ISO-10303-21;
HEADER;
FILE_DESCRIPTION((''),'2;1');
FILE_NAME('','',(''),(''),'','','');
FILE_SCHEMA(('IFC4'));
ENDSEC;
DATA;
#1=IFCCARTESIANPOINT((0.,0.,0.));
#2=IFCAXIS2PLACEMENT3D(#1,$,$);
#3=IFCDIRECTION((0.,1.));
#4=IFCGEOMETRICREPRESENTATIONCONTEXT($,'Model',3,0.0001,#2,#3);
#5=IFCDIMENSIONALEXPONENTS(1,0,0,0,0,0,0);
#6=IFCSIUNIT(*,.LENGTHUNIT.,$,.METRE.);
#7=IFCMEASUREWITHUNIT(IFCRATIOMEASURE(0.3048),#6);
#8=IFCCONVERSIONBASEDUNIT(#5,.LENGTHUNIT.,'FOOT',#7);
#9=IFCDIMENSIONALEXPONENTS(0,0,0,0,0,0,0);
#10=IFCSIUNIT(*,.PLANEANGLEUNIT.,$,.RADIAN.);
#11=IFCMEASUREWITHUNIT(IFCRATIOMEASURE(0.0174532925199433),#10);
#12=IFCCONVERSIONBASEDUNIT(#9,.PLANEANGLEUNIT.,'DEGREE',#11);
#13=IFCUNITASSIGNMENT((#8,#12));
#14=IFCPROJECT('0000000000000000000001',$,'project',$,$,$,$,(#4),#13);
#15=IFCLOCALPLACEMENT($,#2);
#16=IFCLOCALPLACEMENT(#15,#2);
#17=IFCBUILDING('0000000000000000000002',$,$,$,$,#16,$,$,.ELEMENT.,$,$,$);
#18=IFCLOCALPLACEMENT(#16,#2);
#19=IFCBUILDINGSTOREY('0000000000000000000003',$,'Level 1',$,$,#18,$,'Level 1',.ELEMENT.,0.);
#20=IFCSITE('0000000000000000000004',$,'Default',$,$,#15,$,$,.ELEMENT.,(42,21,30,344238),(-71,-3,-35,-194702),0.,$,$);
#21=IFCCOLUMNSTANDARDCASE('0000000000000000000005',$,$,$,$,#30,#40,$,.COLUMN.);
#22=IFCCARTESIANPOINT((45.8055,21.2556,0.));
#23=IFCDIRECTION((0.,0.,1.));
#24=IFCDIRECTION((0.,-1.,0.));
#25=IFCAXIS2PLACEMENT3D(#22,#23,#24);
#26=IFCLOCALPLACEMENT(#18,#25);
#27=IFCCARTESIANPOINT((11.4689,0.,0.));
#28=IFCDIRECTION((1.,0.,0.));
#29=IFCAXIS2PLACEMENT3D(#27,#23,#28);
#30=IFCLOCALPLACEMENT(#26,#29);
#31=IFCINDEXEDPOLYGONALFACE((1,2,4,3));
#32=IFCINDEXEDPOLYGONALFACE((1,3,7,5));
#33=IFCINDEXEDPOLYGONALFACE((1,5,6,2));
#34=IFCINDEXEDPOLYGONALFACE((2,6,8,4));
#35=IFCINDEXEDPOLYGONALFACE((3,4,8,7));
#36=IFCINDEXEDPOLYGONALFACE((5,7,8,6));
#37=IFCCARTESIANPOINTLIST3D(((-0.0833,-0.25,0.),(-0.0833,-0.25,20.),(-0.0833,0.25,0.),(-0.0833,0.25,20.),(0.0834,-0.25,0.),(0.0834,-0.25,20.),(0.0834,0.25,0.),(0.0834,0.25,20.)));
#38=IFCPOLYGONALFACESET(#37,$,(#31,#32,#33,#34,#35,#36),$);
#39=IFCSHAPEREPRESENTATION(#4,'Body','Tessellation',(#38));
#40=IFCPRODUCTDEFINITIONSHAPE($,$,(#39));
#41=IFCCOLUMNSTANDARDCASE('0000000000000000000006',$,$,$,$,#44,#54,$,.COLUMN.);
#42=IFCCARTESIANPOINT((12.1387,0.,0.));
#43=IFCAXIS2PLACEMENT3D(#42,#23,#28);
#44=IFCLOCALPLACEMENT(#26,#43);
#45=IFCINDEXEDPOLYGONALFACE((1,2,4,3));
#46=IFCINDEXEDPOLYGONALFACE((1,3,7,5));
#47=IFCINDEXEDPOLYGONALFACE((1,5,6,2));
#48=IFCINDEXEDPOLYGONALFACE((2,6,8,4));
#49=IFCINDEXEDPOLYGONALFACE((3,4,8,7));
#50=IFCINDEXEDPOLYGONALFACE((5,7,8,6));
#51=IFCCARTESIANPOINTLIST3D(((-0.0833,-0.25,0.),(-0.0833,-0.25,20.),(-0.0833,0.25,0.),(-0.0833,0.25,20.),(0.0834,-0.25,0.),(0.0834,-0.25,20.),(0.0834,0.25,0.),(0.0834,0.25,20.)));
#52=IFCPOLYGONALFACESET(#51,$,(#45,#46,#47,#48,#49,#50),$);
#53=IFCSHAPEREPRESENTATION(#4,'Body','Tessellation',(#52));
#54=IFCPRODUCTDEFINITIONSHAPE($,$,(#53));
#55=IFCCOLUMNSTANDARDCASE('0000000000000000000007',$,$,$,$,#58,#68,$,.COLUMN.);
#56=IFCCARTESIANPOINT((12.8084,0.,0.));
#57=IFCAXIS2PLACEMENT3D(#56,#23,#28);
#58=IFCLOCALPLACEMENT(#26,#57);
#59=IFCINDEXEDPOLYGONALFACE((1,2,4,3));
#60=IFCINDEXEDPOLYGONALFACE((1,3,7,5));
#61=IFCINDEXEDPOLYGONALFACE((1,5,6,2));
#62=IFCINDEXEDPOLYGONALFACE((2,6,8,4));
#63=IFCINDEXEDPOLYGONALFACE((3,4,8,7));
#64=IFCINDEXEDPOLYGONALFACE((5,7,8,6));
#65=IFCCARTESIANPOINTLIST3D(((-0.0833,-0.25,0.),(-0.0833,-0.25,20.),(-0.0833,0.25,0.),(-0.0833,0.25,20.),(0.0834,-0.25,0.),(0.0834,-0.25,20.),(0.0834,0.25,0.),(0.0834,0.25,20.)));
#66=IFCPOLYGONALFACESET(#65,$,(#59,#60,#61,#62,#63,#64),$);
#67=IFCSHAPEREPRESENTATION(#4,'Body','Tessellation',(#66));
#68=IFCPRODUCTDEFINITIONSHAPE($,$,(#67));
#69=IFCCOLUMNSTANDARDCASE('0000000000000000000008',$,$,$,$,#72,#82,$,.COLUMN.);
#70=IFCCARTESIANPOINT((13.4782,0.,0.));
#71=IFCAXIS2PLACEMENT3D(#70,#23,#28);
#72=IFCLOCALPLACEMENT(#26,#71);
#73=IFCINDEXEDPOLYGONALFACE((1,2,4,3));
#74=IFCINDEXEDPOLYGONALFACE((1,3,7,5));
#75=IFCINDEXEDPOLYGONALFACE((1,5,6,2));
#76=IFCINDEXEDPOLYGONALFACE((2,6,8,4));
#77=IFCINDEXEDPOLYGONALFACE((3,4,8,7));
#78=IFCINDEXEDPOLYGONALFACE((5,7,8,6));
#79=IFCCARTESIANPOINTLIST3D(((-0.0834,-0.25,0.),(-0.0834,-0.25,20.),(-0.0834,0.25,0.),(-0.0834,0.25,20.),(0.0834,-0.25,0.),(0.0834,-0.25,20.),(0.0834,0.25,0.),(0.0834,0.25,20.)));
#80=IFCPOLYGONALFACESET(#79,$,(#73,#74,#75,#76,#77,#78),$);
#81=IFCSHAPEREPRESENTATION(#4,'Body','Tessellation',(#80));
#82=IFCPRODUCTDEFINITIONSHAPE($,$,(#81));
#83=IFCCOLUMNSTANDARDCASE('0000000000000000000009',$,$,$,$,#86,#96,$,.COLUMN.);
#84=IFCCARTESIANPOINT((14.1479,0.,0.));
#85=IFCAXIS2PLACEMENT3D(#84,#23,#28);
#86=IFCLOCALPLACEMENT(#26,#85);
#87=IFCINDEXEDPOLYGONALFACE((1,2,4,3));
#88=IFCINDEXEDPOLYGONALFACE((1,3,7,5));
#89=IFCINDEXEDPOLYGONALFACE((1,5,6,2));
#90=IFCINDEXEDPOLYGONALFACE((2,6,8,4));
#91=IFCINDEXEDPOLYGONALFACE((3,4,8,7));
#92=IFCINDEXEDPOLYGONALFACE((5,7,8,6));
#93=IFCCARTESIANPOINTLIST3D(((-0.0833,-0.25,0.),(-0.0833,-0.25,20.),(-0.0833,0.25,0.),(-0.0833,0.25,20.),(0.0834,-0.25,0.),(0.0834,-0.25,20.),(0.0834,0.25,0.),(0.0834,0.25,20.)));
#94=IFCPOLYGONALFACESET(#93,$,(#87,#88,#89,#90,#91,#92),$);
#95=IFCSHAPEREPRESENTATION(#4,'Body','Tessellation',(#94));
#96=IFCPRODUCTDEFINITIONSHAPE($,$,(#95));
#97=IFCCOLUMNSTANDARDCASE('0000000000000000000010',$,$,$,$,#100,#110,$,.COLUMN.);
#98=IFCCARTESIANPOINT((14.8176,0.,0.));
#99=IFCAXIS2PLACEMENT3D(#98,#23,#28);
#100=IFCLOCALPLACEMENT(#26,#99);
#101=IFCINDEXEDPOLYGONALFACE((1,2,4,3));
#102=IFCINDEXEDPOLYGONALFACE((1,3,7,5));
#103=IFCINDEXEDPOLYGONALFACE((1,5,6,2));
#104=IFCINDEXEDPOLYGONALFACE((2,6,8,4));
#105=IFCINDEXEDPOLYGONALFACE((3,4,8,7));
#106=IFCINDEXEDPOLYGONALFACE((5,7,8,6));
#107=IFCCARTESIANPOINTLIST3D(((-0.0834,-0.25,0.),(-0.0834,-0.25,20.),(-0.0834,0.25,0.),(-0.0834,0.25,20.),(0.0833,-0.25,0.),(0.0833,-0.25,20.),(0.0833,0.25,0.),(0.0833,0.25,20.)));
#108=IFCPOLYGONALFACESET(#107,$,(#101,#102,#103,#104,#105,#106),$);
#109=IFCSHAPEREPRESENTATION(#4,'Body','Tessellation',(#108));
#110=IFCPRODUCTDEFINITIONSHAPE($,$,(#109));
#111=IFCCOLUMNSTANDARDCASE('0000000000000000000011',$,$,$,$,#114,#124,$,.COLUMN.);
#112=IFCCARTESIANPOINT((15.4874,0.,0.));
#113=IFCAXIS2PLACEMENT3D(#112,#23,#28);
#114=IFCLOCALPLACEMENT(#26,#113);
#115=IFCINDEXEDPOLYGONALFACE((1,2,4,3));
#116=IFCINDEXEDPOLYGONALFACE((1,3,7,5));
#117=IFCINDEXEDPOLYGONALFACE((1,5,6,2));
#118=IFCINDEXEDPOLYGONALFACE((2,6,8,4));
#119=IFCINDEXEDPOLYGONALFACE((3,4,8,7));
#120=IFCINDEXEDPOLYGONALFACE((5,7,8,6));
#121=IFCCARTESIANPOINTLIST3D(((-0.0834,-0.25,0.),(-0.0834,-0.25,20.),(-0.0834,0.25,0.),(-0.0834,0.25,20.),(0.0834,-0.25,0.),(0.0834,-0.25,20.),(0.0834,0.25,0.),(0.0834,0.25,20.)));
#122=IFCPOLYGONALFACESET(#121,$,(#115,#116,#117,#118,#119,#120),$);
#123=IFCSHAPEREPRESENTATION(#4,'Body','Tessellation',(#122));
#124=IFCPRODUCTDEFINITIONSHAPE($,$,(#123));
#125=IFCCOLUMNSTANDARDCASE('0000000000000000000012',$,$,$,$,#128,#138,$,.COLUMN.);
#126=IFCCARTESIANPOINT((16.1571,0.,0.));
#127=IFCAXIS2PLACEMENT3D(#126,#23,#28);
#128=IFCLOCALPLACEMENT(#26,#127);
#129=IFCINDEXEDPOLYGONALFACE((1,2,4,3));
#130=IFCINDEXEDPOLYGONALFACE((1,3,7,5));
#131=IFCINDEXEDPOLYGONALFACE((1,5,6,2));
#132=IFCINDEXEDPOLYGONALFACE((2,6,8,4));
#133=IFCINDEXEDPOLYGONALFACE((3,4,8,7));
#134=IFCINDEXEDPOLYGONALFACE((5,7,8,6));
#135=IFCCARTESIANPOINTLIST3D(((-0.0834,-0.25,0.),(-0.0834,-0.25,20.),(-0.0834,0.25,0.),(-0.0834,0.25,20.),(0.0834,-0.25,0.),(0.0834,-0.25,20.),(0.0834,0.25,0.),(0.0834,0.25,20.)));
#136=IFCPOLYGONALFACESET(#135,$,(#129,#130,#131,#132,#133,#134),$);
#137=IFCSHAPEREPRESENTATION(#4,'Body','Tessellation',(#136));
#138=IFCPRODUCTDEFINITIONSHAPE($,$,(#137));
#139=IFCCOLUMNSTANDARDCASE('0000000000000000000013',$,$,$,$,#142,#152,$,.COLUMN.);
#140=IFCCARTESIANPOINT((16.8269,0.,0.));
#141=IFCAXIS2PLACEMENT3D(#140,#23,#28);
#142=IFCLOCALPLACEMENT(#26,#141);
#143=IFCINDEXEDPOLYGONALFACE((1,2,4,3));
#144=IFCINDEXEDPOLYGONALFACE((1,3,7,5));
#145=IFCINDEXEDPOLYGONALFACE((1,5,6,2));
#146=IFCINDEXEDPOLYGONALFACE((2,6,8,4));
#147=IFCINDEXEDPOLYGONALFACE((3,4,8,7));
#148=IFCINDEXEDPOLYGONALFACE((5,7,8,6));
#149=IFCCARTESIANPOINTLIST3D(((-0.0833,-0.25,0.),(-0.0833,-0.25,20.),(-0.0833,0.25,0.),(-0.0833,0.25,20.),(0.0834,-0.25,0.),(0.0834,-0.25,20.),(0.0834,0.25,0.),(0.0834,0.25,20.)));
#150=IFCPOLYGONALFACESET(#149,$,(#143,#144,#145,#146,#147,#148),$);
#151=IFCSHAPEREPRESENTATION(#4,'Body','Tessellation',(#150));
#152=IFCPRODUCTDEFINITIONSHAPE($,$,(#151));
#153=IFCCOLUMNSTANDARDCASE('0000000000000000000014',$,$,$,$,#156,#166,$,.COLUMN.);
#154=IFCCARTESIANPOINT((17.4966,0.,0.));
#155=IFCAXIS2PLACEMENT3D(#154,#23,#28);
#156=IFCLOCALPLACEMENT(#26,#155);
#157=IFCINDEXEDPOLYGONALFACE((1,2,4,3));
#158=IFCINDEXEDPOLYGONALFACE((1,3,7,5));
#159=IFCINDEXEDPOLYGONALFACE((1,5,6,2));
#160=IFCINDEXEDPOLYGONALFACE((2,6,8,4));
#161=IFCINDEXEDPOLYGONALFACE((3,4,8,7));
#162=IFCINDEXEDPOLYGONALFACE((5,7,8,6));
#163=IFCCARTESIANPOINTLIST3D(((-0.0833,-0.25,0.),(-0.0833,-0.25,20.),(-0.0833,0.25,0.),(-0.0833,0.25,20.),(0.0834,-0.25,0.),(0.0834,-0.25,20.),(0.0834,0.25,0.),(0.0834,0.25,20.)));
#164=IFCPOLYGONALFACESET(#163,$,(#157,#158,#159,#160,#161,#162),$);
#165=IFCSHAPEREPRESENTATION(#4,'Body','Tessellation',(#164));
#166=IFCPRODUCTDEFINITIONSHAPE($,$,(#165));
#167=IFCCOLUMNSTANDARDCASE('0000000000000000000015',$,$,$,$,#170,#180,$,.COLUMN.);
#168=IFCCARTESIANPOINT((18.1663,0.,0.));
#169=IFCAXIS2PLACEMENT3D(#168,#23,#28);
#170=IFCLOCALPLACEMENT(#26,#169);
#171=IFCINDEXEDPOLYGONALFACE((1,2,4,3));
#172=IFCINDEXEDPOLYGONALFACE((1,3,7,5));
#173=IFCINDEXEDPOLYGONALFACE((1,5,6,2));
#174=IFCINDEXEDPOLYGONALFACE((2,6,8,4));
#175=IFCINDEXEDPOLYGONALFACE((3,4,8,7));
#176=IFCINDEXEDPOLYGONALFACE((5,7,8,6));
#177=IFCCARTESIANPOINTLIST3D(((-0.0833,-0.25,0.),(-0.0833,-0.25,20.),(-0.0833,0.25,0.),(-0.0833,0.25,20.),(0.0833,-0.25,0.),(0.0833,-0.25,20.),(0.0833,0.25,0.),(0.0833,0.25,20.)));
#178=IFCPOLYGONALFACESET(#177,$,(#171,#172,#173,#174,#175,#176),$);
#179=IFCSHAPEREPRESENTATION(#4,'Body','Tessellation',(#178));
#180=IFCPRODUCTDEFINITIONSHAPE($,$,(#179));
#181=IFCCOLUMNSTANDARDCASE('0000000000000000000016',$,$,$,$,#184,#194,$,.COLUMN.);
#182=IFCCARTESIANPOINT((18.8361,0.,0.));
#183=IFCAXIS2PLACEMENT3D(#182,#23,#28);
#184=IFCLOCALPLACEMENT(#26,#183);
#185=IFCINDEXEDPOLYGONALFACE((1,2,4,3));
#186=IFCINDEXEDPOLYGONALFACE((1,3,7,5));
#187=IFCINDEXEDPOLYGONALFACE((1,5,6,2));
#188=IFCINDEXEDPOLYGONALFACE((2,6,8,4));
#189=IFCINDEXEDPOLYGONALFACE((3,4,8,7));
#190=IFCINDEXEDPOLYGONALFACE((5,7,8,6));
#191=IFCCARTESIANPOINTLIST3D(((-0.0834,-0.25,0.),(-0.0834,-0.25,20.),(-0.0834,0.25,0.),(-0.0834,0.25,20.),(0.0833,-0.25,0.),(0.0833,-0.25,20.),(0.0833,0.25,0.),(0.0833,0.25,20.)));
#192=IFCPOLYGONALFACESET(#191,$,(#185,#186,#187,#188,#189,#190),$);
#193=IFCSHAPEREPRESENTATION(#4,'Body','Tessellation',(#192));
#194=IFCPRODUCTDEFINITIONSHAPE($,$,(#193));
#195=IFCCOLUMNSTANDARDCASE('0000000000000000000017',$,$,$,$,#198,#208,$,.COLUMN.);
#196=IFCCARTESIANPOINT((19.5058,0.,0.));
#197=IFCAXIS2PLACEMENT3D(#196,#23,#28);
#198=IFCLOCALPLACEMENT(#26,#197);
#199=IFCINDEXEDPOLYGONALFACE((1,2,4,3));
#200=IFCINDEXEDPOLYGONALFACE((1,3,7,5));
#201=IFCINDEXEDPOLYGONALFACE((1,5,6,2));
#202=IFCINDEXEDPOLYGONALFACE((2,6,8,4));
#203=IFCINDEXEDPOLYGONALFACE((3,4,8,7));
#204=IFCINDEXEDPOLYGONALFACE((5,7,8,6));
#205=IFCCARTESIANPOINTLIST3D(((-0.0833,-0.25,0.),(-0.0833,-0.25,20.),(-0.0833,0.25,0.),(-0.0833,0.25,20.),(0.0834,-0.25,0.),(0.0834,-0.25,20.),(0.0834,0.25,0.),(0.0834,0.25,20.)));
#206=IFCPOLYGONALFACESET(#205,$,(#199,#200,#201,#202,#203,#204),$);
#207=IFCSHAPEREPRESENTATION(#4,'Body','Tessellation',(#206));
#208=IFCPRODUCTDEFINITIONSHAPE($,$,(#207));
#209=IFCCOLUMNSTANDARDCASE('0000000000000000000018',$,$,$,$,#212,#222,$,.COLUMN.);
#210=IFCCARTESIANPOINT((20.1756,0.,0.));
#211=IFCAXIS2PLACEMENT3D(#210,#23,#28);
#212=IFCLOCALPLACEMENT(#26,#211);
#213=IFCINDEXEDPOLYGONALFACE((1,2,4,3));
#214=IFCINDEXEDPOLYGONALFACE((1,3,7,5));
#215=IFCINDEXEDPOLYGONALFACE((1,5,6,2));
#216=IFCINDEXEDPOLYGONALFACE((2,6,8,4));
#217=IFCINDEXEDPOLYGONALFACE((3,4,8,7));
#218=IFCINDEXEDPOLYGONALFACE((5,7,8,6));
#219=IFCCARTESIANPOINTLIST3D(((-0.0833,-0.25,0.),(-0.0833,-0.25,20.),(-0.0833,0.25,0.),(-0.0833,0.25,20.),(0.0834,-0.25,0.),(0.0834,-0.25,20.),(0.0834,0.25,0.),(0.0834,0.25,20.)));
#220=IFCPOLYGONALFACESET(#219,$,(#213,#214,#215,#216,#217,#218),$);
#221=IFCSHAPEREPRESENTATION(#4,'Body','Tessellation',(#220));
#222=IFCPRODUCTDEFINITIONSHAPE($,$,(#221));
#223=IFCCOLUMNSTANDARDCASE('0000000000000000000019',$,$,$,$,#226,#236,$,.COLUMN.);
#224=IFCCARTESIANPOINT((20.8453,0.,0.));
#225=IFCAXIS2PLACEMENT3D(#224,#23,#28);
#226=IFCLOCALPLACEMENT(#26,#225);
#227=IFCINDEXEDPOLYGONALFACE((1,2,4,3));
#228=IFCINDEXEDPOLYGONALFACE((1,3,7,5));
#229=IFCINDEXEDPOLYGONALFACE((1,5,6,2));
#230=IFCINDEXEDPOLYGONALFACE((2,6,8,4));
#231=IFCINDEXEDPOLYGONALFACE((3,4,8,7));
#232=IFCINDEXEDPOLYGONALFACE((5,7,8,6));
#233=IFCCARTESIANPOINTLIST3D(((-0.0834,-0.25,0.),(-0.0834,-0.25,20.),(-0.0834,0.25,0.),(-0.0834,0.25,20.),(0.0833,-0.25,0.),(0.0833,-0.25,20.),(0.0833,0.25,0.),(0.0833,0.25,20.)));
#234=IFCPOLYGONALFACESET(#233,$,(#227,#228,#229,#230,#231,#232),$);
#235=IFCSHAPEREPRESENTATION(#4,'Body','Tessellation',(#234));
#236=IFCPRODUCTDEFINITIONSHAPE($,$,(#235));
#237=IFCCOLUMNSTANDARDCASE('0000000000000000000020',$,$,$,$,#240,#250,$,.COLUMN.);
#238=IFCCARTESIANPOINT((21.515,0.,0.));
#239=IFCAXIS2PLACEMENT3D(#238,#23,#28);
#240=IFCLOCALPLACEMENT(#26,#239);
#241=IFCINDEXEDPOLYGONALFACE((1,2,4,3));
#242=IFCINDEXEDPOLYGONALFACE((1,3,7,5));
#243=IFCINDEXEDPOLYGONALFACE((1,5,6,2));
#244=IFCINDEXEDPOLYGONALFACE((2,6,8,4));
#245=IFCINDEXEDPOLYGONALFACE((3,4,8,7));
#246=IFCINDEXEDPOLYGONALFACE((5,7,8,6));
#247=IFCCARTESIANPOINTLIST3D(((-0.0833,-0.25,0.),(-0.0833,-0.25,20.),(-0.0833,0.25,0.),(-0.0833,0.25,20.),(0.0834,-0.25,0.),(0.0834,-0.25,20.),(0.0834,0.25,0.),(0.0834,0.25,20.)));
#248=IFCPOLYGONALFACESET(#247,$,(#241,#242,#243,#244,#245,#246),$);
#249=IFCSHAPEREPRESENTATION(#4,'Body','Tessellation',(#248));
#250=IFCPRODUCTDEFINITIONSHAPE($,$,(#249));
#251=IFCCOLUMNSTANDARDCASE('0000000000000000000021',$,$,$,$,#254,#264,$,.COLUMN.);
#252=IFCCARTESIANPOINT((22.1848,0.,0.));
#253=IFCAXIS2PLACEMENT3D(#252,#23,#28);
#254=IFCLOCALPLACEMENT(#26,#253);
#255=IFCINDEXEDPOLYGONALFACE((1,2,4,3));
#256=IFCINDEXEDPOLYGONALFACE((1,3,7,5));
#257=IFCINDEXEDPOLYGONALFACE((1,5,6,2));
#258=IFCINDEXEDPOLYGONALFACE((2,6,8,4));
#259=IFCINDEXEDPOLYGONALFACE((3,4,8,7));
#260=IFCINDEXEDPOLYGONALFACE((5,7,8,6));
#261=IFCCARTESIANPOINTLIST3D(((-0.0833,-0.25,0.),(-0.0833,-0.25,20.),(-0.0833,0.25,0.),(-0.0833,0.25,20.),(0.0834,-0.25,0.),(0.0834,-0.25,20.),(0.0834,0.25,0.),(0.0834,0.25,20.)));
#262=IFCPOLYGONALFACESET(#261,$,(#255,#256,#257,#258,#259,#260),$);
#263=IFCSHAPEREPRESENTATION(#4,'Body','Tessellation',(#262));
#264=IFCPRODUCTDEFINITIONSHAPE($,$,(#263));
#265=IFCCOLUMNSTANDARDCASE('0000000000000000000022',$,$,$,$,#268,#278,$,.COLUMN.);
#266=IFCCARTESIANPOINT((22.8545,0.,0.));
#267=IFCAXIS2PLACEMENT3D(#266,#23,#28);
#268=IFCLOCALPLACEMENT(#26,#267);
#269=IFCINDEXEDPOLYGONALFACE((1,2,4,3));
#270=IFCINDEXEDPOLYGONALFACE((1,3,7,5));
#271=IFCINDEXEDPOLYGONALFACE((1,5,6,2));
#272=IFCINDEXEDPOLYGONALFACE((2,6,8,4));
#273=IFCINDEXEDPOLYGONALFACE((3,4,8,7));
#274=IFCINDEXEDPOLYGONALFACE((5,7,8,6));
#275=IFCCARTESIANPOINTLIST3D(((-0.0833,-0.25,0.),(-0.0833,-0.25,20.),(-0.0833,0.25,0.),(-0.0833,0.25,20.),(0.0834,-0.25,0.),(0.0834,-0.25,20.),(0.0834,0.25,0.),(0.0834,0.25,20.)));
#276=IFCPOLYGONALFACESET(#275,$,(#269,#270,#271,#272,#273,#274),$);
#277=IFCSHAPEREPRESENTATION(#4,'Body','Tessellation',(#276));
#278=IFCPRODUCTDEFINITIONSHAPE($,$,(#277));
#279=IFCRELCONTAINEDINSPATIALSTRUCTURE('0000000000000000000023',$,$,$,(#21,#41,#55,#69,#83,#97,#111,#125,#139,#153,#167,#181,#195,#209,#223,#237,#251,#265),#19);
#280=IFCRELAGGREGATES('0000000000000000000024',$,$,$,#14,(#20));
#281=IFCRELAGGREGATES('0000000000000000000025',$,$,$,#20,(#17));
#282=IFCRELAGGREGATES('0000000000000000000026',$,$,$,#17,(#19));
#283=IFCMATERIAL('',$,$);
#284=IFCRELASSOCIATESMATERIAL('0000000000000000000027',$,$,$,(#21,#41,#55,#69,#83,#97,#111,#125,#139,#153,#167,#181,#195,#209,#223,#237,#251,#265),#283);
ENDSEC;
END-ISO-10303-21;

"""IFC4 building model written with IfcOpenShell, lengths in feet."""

from ifc_helpers import new_model, entity, si_unit, converted_unit, direction, frame, origin, place, context, project, spatial, rectangle, extrude, material, element, save


model = new_model("IFC4")

# Units and contexts
model_context = context("Model", 3, precision=0.0001, world=origin(), true_north=direction((0.0, 1.0)))
ifc_project = project(units=[converted_unit("LENGTHUNIT", "FOOT", entity("IfcRatioMeasure", 0.3048), si_unit("LENGTHUNIT", "METRE"), dimensions=[1, 0, 0, 0, 0, 0, 0]), converted_unit("PLANEANGLEUNIT", "DEGREE", entity("IfcRatioMeasure", 0.0174532925199433), si_unit("PLANEANGLEUNIT", "RADIAN"), dimensions=[0, 0, 0, 0, 0, 0, 0])], contexts=[model_context])

# Site, building, storey
site_placement = place(None, origin())
site = spatial("IfcSite", under=ifc_project, at=site_placement, Name="Default", CompositionType="ELEMENT", RefLatitude=(42, 21, 30, 344238), RefLongitude=(-71, -3, -35, -194702), RefElevation=0.0)
building_placement = place(site_placement, origin())
building = spatial("IfcBuilding", under=site, at=building_placement, CompositionType="ELEMENT")
storey_placement = place(building_placement, origin())
storey = spatial("IfcBuildingStorey", under=building, at=storey_placement, Name="Level 1", LongName="Level 1", CompositionType="ELEMENT", Elevation=0.0)

# Columns
ifc_material_1 = material(Name="")
placement = place(storey_placement, frame((45.8055, 21.2556, 0.0), z_axis=(0.0, 0.0, 1.0), x_axis=(0.0, -1.0, 0.0)))
for number, where, z_axis, x_axis in (
    (1, (11.4689, 0.0, 0.0), (0.0, 0.0, 1.0), (1.0, 0.0, 0.0)),
    (2, (12.1387, 0.0, 0.0), (0.0, 0.0, 1.0), (1.0, 0.0, 0.0)),
    (3, (12.8084, 0.0, 0.0), (0.0, 0.0, 1.0), (1.0, 0.0, 0.0)),
    (4, (13.4782, 0.0, 0.0), (0.0, 0.0, 1.0), (1.0, 0.0, 0.0)),
    (5, (14.1479, 0.0, 0.0), (0.0, 0.0, 1.0), (1.0, 0.0, 0.0)),
    (6, (14.8176, 0.0, 0.0), (0.0, 0.0, 1.0), (1.0, 0.0, 0.0)),
    (7, (15.4874, 0.0, 0.0), (0.0, 0.0, 1.0), (1.0, 0.0, 0.0)),
    (8, (16.1571, 0.0, 0.0), (0.0, 0.0, 1.0), (1.0, 0.0, 0.0)),
    (9, (16.8269, 0.0, 0.0), (0.0, 0.0, 1.0), (1.0, 0.0, 0.0)),
    (10, (17.4966, 0.0, 0.0), (0.0, 0.0, 1.0), (1.0, 0.0, 0.0)),
    (11, (18.1663, 0.0, 0.0), (0.0, 0.0, 1.0), (1.0, 0.0, 0.0)),
    (12, (18.8361, 0.0, 0.0), (0.0, 0.0, 1.0), (1.0, 0.0, 0.0)),
    (13, (19.5058, 0.0, 0.0), (0.0, 0.0, 1.0), (1.0, 0.0, 0.0)),
    (14, (20.1756, 0.0, 0.0), (0.0, 0.0, 1.0), (1.0, 0.0, 0.0)),
    (15, (20.8453, 0.0, 0.0), (0.0, 0.0, 1.0), (1.0, 0.0, 0.0)),
    (16, (21.515, 0.0, 0.0), (0.0, 0.0, 1.0), (1.0, 0.0, 0.0)),
    (17, (22.1848, 0.0, 0.0), (0.0, 0.0, 1.0), (1.0, 0.0, 0.0)),
    (18, (22.8545, 0.0, 0.0), (0.0, 0.0, 1.0), (1.0, 0.0, 0.0)),
):
    element("IfcColumnStandardCase", number, at=place(placement, frame(where, z_axis=z_axis, x_axis=x_axis)), inside=storey, material=ifc_material_1, PredefinedType="COLUMN", context=model_context, shape_type="SweptSolid", body=[
        extrude(rectangle(XDim=0.1667, YDim=0.5), origin(), (0.0, 0.0, 1.0), 20.0),
    ])

save(model, "model.ifc")
